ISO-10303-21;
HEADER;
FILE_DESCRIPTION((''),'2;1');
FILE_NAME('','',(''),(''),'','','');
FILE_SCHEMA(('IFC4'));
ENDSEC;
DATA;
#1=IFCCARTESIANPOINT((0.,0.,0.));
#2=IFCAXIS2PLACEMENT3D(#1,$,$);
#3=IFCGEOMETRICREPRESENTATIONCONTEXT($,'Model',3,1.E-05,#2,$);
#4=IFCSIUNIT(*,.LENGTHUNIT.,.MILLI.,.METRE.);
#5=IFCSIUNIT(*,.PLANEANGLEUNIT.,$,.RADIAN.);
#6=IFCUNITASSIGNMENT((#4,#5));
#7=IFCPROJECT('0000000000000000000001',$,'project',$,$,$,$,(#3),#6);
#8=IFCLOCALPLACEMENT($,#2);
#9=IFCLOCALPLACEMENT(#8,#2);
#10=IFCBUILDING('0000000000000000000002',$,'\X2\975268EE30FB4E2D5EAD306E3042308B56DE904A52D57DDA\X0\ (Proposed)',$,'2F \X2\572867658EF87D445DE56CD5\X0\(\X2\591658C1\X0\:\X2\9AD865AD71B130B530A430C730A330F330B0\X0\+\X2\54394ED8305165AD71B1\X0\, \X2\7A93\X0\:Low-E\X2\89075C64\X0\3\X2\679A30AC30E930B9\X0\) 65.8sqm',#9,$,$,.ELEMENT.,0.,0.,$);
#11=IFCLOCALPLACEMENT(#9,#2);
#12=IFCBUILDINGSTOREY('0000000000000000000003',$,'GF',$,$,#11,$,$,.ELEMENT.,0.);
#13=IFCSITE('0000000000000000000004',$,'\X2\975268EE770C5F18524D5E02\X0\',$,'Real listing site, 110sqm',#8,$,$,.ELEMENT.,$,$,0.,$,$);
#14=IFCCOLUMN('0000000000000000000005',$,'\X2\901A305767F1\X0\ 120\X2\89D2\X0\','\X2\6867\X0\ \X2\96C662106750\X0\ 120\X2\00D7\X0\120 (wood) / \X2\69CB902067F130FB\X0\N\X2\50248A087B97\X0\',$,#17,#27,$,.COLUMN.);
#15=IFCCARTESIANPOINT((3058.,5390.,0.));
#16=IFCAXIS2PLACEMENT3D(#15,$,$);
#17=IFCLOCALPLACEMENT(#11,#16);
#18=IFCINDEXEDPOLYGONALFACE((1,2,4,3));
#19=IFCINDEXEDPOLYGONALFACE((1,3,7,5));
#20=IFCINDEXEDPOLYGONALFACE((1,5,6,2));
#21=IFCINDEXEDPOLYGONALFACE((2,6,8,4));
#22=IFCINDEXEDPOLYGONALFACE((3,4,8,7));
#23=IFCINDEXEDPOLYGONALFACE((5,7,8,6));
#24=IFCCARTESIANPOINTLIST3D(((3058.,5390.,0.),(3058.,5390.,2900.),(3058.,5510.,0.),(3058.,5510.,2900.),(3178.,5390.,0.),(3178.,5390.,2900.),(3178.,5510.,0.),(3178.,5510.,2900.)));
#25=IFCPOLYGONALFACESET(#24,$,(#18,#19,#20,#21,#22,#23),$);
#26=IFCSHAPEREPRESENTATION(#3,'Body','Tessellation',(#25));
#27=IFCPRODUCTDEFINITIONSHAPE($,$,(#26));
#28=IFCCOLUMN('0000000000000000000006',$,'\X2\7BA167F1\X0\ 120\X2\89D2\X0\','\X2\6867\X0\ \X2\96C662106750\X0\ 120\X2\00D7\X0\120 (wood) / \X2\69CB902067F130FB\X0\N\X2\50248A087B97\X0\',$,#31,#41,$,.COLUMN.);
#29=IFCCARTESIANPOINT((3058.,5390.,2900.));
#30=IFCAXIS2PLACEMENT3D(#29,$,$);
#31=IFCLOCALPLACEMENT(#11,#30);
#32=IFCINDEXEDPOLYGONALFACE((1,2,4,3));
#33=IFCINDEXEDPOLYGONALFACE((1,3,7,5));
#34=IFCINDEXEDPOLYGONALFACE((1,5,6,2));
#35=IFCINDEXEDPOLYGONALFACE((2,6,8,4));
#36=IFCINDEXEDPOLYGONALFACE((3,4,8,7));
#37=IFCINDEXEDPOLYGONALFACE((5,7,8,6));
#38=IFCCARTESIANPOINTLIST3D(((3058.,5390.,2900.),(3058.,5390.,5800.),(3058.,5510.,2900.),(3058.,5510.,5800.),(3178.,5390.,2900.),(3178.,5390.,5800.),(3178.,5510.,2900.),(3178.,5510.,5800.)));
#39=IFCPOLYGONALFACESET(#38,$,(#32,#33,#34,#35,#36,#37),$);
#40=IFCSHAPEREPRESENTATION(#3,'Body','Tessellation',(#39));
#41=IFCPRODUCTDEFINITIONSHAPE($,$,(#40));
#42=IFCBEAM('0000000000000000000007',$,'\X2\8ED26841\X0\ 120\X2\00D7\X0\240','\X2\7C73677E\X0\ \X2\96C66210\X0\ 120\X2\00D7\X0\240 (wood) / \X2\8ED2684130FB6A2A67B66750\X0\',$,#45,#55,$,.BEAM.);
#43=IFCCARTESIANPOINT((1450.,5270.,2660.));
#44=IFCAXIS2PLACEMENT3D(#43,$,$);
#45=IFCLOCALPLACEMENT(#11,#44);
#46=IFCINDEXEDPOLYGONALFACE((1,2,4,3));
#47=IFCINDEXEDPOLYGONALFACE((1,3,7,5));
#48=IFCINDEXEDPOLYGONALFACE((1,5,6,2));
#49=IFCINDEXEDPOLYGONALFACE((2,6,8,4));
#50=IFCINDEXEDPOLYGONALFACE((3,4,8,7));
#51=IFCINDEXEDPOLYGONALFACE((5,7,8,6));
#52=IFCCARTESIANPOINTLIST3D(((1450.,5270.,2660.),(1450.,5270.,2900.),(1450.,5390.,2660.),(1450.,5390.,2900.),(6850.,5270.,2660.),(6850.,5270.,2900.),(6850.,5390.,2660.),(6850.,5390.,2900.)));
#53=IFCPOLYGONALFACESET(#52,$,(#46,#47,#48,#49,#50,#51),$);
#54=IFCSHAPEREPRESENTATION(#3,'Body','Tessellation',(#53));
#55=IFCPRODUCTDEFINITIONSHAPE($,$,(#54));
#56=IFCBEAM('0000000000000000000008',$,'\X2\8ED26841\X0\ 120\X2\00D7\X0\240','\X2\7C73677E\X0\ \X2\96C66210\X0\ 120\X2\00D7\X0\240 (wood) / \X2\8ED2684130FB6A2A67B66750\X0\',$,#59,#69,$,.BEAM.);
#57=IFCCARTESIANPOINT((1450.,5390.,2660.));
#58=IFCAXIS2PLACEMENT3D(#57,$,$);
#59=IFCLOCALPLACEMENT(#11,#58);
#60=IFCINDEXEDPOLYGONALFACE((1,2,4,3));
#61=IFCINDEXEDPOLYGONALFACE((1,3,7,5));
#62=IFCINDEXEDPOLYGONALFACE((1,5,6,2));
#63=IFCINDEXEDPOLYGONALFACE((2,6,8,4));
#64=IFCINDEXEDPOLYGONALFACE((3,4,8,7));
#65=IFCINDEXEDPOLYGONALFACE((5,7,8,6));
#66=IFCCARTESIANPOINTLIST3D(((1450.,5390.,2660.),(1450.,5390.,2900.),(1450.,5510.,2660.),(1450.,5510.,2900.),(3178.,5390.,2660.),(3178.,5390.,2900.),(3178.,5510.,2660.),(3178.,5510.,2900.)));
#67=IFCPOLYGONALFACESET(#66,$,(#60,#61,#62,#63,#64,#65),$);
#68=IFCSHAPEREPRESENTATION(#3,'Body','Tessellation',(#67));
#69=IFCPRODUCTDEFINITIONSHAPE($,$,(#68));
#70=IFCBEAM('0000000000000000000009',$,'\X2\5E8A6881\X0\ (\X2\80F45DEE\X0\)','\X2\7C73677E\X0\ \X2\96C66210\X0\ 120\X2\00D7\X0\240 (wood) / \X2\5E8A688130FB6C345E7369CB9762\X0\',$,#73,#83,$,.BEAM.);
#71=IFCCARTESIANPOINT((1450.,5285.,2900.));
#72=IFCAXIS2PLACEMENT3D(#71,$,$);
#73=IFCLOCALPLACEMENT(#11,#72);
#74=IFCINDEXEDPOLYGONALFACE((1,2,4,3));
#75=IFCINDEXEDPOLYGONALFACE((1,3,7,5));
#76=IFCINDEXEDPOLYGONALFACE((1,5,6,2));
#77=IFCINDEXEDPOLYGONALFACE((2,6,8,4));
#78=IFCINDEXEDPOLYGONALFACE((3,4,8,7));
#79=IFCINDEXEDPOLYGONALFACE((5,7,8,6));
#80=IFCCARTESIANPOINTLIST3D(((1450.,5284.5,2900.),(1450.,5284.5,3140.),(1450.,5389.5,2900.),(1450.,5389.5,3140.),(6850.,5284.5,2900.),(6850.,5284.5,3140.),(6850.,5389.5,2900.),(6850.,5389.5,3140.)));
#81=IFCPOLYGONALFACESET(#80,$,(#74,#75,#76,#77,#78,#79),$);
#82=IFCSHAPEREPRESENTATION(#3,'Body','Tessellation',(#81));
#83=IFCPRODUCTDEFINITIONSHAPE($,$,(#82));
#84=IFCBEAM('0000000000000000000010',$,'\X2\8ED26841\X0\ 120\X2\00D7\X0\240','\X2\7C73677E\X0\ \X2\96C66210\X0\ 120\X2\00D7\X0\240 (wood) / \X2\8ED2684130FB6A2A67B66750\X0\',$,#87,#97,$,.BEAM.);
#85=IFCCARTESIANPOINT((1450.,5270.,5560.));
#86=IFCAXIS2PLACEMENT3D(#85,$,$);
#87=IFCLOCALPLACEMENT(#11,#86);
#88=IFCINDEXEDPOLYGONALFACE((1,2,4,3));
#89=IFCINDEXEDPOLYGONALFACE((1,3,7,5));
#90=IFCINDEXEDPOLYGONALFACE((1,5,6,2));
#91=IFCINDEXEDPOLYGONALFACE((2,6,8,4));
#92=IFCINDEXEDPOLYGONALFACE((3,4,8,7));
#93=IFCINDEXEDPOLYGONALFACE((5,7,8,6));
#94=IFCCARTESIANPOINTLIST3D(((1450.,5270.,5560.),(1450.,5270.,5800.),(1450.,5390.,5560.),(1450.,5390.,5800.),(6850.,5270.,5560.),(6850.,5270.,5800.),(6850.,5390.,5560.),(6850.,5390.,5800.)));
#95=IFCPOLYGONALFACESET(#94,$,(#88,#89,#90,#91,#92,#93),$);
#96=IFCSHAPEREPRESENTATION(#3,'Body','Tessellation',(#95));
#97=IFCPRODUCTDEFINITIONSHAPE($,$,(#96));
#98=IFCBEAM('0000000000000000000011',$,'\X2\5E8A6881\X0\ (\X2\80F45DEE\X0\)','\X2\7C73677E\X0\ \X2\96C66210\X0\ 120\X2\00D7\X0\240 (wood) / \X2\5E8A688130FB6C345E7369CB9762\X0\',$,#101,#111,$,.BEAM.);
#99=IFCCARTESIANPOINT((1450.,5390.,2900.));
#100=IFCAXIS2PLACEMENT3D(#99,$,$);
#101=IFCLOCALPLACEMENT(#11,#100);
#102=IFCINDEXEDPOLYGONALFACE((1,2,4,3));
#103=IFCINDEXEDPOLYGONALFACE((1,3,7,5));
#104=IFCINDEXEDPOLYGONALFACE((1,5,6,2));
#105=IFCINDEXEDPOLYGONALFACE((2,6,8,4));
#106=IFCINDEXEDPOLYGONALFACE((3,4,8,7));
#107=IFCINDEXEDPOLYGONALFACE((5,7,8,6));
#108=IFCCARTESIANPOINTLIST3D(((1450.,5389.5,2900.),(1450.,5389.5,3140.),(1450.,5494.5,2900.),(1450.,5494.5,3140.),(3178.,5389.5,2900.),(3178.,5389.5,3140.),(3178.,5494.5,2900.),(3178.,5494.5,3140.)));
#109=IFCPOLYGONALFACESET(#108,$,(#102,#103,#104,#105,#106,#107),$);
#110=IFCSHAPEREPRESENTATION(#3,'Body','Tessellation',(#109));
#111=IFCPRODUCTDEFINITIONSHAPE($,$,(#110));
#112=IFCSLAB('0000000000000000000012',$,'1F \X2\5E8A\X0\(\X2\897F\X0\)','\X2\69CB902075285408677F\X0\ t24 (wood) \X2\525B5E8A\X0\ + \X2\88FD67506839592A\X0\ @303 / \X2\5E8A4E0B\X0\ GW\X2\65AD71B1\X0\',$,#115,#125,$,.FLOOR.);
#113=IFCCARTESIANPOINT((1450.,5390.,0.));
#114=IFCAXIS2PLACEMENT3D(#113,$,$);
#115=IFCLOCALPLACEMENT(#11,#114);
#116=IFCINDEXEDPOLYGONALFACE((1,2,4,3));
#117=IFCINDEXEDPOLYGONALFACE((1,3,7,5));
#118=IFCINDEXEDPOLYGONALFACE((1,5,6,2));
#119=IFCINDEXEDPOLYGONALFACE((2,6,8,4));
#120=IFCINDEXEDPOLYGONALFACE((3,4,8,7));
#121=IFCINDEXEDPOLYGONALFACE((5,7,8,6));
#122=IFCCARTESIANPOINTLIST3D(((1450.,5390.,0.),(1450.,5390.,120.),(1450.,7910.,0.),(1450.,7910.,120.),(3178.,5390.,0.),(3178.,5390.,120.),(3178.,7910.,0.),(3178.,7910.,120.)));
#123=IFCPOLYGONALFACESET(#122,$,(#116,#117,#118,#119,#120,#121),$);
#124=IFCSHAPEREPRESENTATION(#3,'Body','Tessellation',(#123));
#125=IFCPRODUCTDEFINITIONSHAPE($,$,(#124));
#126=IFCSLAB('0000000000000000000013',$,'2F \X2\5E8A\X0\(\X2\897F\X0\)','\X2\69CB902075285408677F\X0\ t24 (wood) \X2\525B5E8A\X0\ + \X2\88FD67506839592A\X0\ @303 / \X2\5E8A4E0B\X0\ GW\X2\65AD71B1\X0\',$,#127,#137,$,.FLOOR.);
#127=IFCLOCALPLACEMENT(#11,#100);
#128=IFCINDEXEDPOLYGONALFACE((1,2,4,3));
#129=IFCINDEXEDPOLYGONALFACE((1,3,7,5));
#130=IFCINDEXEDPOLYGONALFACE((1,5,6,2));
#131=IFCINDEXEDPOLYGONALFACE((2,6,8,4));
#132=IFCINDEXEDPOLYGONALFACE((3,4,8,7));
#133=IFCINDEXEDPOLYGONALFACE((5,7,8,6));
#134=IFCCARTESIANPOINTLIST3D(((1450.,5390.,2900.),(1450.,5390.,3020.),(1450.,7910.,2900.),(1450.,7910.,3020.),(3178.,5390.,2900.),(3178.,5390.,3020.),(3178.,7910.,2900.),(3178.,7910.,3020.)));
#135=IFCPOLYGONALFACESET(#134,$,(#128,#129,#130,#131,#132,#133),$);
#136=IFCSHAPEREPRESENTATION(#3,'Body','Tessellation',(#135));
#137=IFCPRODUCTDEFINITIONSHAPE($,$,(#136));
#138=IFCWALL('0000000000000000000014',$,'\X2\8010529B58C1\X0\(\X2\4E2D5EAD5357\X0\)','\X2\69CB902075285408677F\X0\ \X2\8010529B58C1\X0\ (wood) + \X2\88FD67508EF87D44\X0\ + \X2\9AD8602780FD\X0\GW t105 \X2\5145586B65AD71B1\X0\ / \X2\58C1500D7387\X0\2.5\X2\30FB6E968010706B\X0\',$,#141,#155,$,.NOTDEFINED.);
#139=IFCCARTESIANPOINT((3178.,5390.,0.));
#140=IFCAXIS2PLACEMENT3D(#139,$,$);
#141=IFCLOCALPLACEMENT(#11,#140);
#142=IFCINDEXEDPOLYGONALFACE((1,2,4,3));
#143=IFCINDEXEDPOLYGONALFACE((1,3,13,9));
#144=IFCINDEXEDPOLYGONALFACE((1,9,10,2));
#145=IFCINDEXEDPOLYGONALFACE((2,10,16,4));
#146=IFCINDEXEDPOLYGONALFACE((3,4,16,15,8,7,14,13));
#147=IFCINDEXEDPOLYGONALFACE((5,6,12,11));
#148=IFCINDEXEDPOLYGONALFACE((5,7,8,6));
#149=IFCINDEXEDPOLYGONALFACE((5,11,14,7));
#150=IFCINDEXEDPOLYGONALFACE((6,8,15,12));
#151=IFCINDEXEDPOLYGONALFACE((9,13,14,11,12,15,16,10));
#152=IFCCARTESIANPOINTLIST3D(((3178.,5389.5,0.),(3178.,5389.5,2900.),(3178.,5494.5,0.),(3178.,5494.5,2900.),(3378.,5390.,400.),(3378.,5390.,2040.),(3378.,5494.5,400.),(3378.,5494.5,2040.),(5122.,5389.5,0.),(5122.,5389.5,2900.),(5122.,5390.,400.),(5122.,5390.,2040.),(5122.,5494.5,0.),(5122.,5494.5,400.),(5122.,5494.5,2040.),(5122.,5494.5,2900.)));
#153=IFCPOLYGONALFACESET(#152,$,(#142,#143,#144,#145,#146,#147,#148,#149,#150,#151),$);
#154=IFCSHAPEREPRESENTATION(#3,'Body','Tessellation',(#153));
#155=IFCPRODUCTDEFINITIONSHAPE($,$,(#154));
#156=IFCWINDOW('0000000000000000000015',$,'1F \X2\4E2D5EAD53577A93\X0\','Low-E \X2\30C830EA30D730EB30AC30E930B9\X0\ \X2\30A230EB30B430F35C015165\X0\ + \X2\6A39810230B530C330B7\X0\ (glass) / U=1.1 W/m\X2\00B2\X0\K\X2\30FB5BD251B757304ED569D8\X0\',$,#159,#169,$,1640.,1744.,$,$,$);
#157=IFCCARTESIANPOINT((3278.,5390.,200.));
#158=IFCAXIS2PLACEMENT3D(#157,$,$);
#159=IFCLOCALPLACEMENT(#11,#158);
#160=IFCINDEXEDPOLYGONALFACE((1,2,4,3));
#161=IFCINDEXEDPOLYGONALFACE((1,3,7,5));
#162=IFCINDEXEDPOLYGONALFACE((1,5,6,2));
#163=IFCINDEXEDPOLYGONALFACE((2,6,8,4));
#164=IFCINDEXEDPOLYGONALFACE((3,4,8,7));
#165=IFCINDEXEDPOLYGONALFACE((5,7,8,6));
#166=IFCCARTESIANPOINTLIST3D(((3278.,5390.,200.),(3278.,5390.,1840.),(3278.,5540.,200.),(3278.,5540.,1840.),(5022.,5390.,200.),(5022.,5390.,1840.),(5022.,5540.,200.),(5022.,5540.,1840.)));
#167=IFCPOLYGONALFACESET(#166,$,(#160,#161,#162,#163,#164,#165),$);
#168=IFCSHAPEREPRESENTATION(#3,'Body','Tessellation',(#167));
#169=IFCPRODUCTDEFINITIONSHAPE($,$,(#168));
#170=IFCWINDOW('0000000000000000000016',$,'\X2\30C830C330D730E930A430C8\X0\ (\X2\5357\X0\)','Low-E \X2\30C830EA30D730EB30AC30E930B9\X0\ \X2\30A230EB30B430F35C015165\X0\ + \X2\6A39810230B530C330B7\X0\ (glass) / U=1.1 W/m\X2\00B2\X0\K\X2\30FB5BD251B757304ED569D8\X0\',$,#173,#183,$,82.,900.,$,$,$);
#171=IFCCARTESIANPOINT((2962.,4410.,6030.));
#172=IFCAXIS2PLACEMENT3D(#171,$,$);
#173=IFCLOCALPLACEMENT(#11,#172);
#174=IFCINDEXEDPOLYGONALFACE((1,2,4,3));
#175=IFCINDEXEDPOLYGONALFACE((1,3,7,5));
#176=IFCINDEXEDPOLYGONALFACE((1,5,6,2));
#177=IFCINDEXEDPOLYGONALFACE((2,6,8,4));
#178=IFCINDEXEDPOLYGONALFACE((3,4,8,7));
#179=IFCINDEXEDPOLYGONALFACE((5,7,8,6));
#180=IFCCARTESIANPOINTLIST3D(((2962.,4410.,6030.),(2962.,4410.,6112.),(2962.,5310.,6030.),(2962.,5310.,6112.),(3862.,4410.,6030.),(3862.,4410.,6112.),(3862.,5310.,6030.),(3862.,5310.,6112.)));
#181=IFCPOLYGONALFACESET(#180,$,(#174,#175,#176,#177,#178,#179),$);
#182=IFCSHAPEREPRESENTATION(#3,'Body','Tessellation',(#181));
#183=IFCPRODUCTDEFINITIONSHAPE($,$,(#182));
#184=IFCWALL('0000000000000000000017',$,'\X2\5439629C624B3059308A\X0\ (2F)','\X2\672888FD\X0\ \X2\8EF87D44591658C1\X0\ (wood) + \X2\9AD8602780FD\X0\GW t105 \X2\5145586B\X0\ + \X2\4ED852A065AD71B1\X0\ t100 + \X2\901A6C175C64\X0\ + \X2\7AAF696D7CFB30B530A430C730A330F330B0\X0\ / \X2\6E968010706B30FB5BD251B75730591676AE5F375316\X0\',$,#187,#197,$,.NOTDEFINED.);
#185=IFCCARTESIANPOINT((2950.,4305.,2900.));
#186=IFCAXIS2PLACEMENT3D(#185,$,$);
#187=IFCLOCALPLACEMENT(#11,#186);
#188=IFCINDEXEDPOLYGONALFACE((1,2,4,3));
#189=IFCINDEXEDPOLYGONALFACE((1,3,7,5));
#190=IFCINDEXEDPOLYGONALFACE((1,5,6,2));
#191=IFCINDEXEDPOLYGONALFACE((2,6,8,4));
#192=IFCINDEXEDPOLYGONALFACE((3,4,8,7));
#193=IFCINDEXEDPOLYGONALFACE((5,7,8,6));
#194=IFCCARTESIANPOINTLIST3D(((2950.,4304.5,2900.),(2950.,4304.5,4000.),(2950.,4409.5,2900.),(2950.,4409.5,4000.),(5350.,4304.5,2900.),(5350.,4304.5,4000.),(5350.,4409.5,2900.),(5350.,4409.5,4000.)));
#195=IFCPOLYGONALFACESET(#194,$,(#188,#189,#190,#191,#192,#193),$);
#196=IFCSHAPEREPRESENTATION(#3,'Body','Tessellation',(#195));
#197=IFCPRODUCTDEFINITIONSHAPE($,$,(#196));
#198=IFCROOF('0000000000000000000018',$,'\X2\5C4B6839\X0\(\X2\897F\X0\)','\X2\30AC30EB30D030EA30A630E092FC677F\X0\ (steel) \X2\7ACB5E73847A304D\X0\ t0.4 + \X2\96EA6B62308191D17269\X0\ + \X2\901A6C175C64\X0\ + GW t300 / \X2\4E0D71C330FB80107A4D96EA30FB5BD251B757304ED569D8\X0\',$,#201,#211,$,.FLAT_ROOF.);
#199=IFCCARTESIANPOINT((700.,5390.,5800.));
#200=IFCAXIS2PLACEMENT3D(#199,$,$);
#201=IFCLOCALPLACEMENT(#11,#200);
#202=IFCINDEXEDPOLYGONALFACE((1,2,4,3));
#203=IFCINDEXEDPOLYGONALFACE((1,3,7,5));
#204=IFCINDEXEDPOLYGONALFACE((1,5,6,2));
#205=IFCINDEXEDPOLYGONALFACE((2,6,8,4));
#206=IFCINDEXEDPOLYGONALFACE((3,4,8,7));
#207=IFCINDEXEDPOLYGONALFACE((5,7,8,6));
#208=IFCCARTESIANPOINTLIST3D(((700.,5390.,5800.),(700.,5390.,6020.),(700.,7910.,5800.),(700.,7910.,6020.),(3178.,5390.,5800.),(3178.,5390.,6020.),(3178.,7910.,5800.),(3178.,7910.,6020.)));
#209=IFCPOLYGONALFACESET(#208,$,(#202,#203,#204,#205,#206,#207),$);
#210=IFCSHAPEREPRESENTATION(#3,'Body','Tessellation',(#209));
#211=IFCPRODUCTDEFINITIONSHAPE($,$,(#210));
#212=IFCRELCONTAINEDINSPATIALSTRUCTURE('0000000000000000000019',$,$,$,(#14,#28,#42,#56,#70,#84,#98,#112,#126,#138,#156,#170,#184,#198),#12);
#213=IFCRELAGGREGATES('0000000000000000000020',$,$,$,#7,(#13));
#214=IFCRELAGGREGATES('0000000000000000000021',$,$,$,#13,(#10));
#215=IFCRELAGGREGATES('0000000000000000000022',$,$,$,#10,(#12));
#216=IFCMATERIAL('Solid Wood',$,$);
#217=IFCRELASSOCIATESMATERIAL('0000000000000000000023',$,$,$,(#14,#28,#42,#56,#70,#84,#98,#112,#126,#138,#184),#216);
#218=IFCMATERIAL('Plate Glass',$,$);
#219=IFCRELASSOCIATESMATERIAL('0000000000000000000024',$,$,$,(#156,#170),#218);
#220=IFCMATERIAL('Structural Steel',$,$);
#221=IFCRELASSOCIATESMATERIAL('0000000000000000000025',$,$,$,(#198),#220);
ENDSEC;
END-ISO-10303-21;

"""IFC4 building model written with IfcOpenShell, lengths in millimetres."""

from ifc_helpers import new_model, si_unit, frame, frame_2d, origin, place, context, project, spatial, rectangle, extrude, material, element, fill, save


model = new_model("IFC4")

# Units and contexts
model_context = context("Model", 3, precision=1e-05, world=origin())
ifc_project = project(units=[si_unit("LENGTHUNIT", "METRE", prefix="MILLI"), si_unit("PLANEANGLEUNIT", "RADIAN")], contexts=[model_context])

# Site, building, storey
site_placement = place(None, origin())
site = spatial("IfcSite", under=ifc_project, at=site_placement, Name="青森県弘前市", ObjectType="Real listing site, 110sqm", CompositionType="ELEMENT", RefElevation=0.0)
building_placement = place(site_placement, origin())
building = spatial("IfcBuilding", under=site, at=building_placement, Name="青森・中庭のある回遊動線 (Proposed)", ObjectType="2F 在来軸組工法(外壁:高断熱サイディング+吹付け断熱, 窓:Low-E複層3枚ガラス) 65.8sqm", CompositionType="ELEMENT", ElevationOfRefHeight=0.0, ElevationOfTerrain=0.0)
storey_placement = place(building_placement, origin())
storey = spatial("IfcBuildingStorey", under=building, at=storey_placement, Name="GF", CompositionType="ELEMENT", Elevation=0.0)

# Columns
ifc_material_1 = material(Name="Solid Wood")
column_1_placement = place(storey_placement, frame((3058.0, 5390.0, 0.0)))
element("IfcColumn", 1, at=column_1_placement, inside=storey, material=ifc_material_1, Name="通し柱 120角", Description="桧 集成材 120×120 (wood) / 構造柱・N値計算", PredefinedType="COLUMN", context=model_context, shape_type="SweptSolid", body=[
    extrude(rectangle(XDim=120.0, YDim=120.0, at=frame_2d((60.0, 60.0))), frame((3058.0, 5390.0, 0.0)), (0.0, 0.0, 1.0), 2900.0),
])
column_2_placement = place(storey_placement, frame((3058.0, 5390.0, 2900.0)))
element("IfcColumn", 2, at=column_2_placement, inside=storey, material=ifc_material_1, Name="管柱 120角", Description="桧 集成材 120×120 (wood) / 構造柱・N値計算", PredefinedType="COLUMN", context=model_context, shape_type="SweptSolid", body=[
    extrude(rectangle(XDim=120.0, YDim=120.0, at=frame_2d((60.0, 60.0))), frame((3058.0, 5390.0, 2900.0)), (0.0, 0.0, 1.0), 2900.0),
])

# Beams
beam_1_placement = place(storey_placement, frame((1450.0, 5270.0, 2660.0)))
element("IfcBeam", 3, at=beam_1_placement, inside=storey, material=ifc_material_1, Name="軒桁 120×240", Description="米松 集成 120×240 (wood) / 軒桁・横架材", PredefinedType="BEAM", context=model_context, shape_type="SweptSolid", body=[
    extrude(rectangle(XDim=5400.0, YDim=120.0, at=frame_2d((2700.0, 60.0))), frame((1450.0, 5270.0, 2660.0)), (0.0, 0.0, 1.0), 240.0),
])
beam_2_placement = place(storey_placement, frame((1450.0, 5390.0, 2660.0)))
element("IfcBeam", 4, at=beam_2_placement, inside=storey, material=ifc_material_1, Name="軒桁 120×240", Description="米松 集成 120×240 (wood) / 軒桁・横架材", PredefinedType="BEAM", context=model_context, shape_type="SweptSolid", body=[
    extrude(rectangle(XDim=1728.0, YDim=120.0, at=frame_2d((864.0, 60.0))), frame((1450.0, 5390.0, 2660.0)), (0.0, 0.0, 1.0), 240.0),
])
beam_3_placement = place(storey_placement, frame((1450.0, 5285.0, 2900.0)))
element("IfcBeam", 5, at=beam_3_placement, inside=storey, material=ifc_material_1, Name="床梁 (胴差)", Description="米松 集成 120×240 (wood) / 床梁・水平構面", PredefinedType="BEAM", context=model_context, shape_type="SweptSolid", body=[
    extrude(rectangle(XDim=5400.0, YDim=105.0, at=frame_2d((2700.0, 52.0))), frame((1450.0, 5285.0, 2900.0)), (0.0, 0.0, 1.0), 240.0),
])
beam_4_placement = place(storey_placement, frame((1450.0, 5270.0, 5560.0)))
element("IfcBeam", 6, at=beam_4_placement, inside=storey, material=ifc_material_1, Name="軒桁 120×240", Description="米松 集成 120×240 (wood) / 軒桁・横架材", PredefinedType="BEAM", context=model_context, shape_type="SweptSolid", body=[
    extrude(rectangle(XDim=5400.0, YDim=120.0, at=frame_2d((2700.0, 60.0))), frame((1450.0, 5270.0, 5560.0)), (0.0, 0.0, 1.0), 240.0),
])
beam_5_placement = place(storey_placement, frame((1450.0, 5390.0, 2900.0)))
element("IfcBeam", 7, at=beam_5_placement, inside=storey, material=ifc_material_1, Name="床梁 (胴差)", Description="米松 集成 120×240 (wood) / 床梁・水平構面", PredefinedType="BEAM", context=model_context, shape_type="SweptSolid", body=[
    extrude(rectangle(XDim=1728.0, YDim=105.0, at=frame_2d((864.0, 52.0))), frame((1450.0, 5390.0, 2900.0)), (0.0, 0.0, 1.0), 240.0),
])

# Slabs
slab_1_placement = place(storey_placement, frame((1450.0, 5390.0, 0.0)))
element("IfcSlab", 8, at=slab_1_placement, inside=storey, material=ifc_material_1, Name="1F 床(西)", Description="構造用合板 t24 (wood) 剛床 + 製材根太 @303 / 床下 GW断熱", PredefinedType="FLOOR", context=model_context, shape_type="SweptSolid", body=[
    extrude(rectangle(XDim=1728.0, YDim=2520.0, at=frame_2d((864.0, 1260.0))), frame((1450.0, 5390.0, 0.0)), (0.0, 0.0, 1.0), 120.0),
])
slab_2_placement = place(storey_placement, frame((1450.0, 5390.0, 2900.0)))
element("IfcSlab", 9, at=slab_2_placement, inside=storey, material=ifc_material_1, Name="2F 床(西)", Description="構造用合板 t24 (wood) 剛床 + 製材根太 @303 / 床下 GW断熱", PredefinedType="FLOOR", context=model_context, shape_type="SweptSolid", body=[
    extrude(rectangle(XDim=1728.0, YDim=2520.0, at=frame_2d((864.0, 1260.0))), frame((1450.0, 5390.0, 2900.0)), (0.0, 0.0, 1.0), 120.0),
])

# Wall, opening, window
wall_1_placement = place(storey_placement, frame((3178.0, 5390.0, 0.0)))
wall_1 = element("IfcWall", 10, at=wall_1_placement, inside=storey, material=ifc_material_1, Name="耐力壁(中庭南)", Description="構造用合板 耐力壁 (wood) + 製材軸組 + 高性能GW t105 充填断熱 / 壁倍率2.5・準耐火", PredefinedType="NOTDEFINED", context=model_context, shape_type="SweptSolid", body=[
    extrude(rectangle(XDim=1944.0, YDim=105.0, at=frame_2d((972.0, 52.0))), frame((3178.0, 5390.0, 0.0)), (0.0, 0.0, 1.0), 2900.0),
])
opening_placement = place(storey_placement, frame((3278.0, 5390.0, 200.0)))
opening = element("IfcOpeningElement", 11, at=opening_placement, cuts=wall_1, PredefinedType="NOTDEFINED", context=model_context, shape_type="SweptSolid", body=[
    extrude(rectangle(XDim=1744.0, YDim=150.0, at=frame_2d((872.0, 75.0))), frame((3278.0, 5390.0, 200.0)), (0.0, 0.0, 1.0), 1640.0),
])
ifc_material_2 = material(Name="Plate Glass")
window_1_placement = place(storey_placement, frame((3278.0, 5390.0, 200.0)))
window_1 = element("IfcWindow", 12, at=window_1_placement, inside=storey, material=ifc_material_2, Name="1F 中庭南窓", Description="Low-E トリプルガラス アルゴン封入 + 樹脂サッシ (glass) / U=1.1 W/m²K・寒冷地仕様", OverallHeight=1640.0, OverallWidth=1744.0, context=model_context, shape_type="SweptSolid", body=[
    extrude(rectangle(XDim=1744.0, YDim=150.0, at=frame_2d((872.0, 75.0))), frame((3278.0, 5390.0, 200.0)), (0.0, 0.0, 1.0), 1640.0),
])
fill(opening, window_1)

# Window
window_2_placement = place(storey_placement, frame((2962.0, 4410.0, 6030.0)))
element("IfcWindow", 13, at=window_2_placement, inside=storey, material=ifc_material_2, Name="トップライト (南)", Description="Low-E トリプルガラス アルゴン封入 + 樹脂サッシ (glass) / U=1.1 W/m²K・寒冷地仕様", OverallHeight=82.0, OverallWidth=900.0, context=model_context, shape_type="SweptSolid", body=[
    extrude(rectangle(XDim=900.0, YDim=900.0, at=frame_2d((450.0, 450.0))), frame((2962.0, 4410.0, 6030.0)), (0.0, 0.0, 1.0), 82.0),
])

# Wall
wall_2_placement = place(storey_placement, frame((2950.0, 4305.0, 2900.0)))
element("IfcWall", 14, at=wall_2_placement, inside=storey, material=ifc_material_1, Name="吹抜手すり (2F)", Description="木製 軸組外壁 (wood) + 高性能GW t105 充填 + 付加断熱 t100 + 通気層 + 窯業系サイディング / 準耐火・寒冷地外皮強化", PredefinedType="NOTDEFINED", context=model_context, shape_type="SweptSolid", body=[
    extrude(rectangle(XDim=2400.0, YDim=105.0, at=frame_2d((1200.0, 52.0))), frame((2950.0, 4305.0, 2900.0)), (0.0, 0.0, 1.0), 1100.0),
])

# Roof
ifc_material_3 = material(Name="Structural Steel")
for number, where, name in (
    (15, (700.0, 5390.0, 5800.0), "屋根(西)"),
):
    element("IfcRoof", number, at=place(storey_placement, frame(where)), inside=storey, material=ifc_material_3, Name=name, Description="ガルバリウム鋼板 (steel) 立平葺き t0.4 + 雪止め金物 + 通気層 + GW t300 / 不燃・耐積雪・寒冷地仕様", PredefinedType="FLAT_ROOF", context=model_context, shape_type="SweptSolid", body=[
        extrude(rectangle(XDim=2478.0, YDim=2520.0, at=frame_2d((1239.0, 1260.0))), frame((700.0, 5390.0, 5800.0)), (0.0, 0.0, 1.0), 220.0),
    ])

save(model, "model.ifc")
